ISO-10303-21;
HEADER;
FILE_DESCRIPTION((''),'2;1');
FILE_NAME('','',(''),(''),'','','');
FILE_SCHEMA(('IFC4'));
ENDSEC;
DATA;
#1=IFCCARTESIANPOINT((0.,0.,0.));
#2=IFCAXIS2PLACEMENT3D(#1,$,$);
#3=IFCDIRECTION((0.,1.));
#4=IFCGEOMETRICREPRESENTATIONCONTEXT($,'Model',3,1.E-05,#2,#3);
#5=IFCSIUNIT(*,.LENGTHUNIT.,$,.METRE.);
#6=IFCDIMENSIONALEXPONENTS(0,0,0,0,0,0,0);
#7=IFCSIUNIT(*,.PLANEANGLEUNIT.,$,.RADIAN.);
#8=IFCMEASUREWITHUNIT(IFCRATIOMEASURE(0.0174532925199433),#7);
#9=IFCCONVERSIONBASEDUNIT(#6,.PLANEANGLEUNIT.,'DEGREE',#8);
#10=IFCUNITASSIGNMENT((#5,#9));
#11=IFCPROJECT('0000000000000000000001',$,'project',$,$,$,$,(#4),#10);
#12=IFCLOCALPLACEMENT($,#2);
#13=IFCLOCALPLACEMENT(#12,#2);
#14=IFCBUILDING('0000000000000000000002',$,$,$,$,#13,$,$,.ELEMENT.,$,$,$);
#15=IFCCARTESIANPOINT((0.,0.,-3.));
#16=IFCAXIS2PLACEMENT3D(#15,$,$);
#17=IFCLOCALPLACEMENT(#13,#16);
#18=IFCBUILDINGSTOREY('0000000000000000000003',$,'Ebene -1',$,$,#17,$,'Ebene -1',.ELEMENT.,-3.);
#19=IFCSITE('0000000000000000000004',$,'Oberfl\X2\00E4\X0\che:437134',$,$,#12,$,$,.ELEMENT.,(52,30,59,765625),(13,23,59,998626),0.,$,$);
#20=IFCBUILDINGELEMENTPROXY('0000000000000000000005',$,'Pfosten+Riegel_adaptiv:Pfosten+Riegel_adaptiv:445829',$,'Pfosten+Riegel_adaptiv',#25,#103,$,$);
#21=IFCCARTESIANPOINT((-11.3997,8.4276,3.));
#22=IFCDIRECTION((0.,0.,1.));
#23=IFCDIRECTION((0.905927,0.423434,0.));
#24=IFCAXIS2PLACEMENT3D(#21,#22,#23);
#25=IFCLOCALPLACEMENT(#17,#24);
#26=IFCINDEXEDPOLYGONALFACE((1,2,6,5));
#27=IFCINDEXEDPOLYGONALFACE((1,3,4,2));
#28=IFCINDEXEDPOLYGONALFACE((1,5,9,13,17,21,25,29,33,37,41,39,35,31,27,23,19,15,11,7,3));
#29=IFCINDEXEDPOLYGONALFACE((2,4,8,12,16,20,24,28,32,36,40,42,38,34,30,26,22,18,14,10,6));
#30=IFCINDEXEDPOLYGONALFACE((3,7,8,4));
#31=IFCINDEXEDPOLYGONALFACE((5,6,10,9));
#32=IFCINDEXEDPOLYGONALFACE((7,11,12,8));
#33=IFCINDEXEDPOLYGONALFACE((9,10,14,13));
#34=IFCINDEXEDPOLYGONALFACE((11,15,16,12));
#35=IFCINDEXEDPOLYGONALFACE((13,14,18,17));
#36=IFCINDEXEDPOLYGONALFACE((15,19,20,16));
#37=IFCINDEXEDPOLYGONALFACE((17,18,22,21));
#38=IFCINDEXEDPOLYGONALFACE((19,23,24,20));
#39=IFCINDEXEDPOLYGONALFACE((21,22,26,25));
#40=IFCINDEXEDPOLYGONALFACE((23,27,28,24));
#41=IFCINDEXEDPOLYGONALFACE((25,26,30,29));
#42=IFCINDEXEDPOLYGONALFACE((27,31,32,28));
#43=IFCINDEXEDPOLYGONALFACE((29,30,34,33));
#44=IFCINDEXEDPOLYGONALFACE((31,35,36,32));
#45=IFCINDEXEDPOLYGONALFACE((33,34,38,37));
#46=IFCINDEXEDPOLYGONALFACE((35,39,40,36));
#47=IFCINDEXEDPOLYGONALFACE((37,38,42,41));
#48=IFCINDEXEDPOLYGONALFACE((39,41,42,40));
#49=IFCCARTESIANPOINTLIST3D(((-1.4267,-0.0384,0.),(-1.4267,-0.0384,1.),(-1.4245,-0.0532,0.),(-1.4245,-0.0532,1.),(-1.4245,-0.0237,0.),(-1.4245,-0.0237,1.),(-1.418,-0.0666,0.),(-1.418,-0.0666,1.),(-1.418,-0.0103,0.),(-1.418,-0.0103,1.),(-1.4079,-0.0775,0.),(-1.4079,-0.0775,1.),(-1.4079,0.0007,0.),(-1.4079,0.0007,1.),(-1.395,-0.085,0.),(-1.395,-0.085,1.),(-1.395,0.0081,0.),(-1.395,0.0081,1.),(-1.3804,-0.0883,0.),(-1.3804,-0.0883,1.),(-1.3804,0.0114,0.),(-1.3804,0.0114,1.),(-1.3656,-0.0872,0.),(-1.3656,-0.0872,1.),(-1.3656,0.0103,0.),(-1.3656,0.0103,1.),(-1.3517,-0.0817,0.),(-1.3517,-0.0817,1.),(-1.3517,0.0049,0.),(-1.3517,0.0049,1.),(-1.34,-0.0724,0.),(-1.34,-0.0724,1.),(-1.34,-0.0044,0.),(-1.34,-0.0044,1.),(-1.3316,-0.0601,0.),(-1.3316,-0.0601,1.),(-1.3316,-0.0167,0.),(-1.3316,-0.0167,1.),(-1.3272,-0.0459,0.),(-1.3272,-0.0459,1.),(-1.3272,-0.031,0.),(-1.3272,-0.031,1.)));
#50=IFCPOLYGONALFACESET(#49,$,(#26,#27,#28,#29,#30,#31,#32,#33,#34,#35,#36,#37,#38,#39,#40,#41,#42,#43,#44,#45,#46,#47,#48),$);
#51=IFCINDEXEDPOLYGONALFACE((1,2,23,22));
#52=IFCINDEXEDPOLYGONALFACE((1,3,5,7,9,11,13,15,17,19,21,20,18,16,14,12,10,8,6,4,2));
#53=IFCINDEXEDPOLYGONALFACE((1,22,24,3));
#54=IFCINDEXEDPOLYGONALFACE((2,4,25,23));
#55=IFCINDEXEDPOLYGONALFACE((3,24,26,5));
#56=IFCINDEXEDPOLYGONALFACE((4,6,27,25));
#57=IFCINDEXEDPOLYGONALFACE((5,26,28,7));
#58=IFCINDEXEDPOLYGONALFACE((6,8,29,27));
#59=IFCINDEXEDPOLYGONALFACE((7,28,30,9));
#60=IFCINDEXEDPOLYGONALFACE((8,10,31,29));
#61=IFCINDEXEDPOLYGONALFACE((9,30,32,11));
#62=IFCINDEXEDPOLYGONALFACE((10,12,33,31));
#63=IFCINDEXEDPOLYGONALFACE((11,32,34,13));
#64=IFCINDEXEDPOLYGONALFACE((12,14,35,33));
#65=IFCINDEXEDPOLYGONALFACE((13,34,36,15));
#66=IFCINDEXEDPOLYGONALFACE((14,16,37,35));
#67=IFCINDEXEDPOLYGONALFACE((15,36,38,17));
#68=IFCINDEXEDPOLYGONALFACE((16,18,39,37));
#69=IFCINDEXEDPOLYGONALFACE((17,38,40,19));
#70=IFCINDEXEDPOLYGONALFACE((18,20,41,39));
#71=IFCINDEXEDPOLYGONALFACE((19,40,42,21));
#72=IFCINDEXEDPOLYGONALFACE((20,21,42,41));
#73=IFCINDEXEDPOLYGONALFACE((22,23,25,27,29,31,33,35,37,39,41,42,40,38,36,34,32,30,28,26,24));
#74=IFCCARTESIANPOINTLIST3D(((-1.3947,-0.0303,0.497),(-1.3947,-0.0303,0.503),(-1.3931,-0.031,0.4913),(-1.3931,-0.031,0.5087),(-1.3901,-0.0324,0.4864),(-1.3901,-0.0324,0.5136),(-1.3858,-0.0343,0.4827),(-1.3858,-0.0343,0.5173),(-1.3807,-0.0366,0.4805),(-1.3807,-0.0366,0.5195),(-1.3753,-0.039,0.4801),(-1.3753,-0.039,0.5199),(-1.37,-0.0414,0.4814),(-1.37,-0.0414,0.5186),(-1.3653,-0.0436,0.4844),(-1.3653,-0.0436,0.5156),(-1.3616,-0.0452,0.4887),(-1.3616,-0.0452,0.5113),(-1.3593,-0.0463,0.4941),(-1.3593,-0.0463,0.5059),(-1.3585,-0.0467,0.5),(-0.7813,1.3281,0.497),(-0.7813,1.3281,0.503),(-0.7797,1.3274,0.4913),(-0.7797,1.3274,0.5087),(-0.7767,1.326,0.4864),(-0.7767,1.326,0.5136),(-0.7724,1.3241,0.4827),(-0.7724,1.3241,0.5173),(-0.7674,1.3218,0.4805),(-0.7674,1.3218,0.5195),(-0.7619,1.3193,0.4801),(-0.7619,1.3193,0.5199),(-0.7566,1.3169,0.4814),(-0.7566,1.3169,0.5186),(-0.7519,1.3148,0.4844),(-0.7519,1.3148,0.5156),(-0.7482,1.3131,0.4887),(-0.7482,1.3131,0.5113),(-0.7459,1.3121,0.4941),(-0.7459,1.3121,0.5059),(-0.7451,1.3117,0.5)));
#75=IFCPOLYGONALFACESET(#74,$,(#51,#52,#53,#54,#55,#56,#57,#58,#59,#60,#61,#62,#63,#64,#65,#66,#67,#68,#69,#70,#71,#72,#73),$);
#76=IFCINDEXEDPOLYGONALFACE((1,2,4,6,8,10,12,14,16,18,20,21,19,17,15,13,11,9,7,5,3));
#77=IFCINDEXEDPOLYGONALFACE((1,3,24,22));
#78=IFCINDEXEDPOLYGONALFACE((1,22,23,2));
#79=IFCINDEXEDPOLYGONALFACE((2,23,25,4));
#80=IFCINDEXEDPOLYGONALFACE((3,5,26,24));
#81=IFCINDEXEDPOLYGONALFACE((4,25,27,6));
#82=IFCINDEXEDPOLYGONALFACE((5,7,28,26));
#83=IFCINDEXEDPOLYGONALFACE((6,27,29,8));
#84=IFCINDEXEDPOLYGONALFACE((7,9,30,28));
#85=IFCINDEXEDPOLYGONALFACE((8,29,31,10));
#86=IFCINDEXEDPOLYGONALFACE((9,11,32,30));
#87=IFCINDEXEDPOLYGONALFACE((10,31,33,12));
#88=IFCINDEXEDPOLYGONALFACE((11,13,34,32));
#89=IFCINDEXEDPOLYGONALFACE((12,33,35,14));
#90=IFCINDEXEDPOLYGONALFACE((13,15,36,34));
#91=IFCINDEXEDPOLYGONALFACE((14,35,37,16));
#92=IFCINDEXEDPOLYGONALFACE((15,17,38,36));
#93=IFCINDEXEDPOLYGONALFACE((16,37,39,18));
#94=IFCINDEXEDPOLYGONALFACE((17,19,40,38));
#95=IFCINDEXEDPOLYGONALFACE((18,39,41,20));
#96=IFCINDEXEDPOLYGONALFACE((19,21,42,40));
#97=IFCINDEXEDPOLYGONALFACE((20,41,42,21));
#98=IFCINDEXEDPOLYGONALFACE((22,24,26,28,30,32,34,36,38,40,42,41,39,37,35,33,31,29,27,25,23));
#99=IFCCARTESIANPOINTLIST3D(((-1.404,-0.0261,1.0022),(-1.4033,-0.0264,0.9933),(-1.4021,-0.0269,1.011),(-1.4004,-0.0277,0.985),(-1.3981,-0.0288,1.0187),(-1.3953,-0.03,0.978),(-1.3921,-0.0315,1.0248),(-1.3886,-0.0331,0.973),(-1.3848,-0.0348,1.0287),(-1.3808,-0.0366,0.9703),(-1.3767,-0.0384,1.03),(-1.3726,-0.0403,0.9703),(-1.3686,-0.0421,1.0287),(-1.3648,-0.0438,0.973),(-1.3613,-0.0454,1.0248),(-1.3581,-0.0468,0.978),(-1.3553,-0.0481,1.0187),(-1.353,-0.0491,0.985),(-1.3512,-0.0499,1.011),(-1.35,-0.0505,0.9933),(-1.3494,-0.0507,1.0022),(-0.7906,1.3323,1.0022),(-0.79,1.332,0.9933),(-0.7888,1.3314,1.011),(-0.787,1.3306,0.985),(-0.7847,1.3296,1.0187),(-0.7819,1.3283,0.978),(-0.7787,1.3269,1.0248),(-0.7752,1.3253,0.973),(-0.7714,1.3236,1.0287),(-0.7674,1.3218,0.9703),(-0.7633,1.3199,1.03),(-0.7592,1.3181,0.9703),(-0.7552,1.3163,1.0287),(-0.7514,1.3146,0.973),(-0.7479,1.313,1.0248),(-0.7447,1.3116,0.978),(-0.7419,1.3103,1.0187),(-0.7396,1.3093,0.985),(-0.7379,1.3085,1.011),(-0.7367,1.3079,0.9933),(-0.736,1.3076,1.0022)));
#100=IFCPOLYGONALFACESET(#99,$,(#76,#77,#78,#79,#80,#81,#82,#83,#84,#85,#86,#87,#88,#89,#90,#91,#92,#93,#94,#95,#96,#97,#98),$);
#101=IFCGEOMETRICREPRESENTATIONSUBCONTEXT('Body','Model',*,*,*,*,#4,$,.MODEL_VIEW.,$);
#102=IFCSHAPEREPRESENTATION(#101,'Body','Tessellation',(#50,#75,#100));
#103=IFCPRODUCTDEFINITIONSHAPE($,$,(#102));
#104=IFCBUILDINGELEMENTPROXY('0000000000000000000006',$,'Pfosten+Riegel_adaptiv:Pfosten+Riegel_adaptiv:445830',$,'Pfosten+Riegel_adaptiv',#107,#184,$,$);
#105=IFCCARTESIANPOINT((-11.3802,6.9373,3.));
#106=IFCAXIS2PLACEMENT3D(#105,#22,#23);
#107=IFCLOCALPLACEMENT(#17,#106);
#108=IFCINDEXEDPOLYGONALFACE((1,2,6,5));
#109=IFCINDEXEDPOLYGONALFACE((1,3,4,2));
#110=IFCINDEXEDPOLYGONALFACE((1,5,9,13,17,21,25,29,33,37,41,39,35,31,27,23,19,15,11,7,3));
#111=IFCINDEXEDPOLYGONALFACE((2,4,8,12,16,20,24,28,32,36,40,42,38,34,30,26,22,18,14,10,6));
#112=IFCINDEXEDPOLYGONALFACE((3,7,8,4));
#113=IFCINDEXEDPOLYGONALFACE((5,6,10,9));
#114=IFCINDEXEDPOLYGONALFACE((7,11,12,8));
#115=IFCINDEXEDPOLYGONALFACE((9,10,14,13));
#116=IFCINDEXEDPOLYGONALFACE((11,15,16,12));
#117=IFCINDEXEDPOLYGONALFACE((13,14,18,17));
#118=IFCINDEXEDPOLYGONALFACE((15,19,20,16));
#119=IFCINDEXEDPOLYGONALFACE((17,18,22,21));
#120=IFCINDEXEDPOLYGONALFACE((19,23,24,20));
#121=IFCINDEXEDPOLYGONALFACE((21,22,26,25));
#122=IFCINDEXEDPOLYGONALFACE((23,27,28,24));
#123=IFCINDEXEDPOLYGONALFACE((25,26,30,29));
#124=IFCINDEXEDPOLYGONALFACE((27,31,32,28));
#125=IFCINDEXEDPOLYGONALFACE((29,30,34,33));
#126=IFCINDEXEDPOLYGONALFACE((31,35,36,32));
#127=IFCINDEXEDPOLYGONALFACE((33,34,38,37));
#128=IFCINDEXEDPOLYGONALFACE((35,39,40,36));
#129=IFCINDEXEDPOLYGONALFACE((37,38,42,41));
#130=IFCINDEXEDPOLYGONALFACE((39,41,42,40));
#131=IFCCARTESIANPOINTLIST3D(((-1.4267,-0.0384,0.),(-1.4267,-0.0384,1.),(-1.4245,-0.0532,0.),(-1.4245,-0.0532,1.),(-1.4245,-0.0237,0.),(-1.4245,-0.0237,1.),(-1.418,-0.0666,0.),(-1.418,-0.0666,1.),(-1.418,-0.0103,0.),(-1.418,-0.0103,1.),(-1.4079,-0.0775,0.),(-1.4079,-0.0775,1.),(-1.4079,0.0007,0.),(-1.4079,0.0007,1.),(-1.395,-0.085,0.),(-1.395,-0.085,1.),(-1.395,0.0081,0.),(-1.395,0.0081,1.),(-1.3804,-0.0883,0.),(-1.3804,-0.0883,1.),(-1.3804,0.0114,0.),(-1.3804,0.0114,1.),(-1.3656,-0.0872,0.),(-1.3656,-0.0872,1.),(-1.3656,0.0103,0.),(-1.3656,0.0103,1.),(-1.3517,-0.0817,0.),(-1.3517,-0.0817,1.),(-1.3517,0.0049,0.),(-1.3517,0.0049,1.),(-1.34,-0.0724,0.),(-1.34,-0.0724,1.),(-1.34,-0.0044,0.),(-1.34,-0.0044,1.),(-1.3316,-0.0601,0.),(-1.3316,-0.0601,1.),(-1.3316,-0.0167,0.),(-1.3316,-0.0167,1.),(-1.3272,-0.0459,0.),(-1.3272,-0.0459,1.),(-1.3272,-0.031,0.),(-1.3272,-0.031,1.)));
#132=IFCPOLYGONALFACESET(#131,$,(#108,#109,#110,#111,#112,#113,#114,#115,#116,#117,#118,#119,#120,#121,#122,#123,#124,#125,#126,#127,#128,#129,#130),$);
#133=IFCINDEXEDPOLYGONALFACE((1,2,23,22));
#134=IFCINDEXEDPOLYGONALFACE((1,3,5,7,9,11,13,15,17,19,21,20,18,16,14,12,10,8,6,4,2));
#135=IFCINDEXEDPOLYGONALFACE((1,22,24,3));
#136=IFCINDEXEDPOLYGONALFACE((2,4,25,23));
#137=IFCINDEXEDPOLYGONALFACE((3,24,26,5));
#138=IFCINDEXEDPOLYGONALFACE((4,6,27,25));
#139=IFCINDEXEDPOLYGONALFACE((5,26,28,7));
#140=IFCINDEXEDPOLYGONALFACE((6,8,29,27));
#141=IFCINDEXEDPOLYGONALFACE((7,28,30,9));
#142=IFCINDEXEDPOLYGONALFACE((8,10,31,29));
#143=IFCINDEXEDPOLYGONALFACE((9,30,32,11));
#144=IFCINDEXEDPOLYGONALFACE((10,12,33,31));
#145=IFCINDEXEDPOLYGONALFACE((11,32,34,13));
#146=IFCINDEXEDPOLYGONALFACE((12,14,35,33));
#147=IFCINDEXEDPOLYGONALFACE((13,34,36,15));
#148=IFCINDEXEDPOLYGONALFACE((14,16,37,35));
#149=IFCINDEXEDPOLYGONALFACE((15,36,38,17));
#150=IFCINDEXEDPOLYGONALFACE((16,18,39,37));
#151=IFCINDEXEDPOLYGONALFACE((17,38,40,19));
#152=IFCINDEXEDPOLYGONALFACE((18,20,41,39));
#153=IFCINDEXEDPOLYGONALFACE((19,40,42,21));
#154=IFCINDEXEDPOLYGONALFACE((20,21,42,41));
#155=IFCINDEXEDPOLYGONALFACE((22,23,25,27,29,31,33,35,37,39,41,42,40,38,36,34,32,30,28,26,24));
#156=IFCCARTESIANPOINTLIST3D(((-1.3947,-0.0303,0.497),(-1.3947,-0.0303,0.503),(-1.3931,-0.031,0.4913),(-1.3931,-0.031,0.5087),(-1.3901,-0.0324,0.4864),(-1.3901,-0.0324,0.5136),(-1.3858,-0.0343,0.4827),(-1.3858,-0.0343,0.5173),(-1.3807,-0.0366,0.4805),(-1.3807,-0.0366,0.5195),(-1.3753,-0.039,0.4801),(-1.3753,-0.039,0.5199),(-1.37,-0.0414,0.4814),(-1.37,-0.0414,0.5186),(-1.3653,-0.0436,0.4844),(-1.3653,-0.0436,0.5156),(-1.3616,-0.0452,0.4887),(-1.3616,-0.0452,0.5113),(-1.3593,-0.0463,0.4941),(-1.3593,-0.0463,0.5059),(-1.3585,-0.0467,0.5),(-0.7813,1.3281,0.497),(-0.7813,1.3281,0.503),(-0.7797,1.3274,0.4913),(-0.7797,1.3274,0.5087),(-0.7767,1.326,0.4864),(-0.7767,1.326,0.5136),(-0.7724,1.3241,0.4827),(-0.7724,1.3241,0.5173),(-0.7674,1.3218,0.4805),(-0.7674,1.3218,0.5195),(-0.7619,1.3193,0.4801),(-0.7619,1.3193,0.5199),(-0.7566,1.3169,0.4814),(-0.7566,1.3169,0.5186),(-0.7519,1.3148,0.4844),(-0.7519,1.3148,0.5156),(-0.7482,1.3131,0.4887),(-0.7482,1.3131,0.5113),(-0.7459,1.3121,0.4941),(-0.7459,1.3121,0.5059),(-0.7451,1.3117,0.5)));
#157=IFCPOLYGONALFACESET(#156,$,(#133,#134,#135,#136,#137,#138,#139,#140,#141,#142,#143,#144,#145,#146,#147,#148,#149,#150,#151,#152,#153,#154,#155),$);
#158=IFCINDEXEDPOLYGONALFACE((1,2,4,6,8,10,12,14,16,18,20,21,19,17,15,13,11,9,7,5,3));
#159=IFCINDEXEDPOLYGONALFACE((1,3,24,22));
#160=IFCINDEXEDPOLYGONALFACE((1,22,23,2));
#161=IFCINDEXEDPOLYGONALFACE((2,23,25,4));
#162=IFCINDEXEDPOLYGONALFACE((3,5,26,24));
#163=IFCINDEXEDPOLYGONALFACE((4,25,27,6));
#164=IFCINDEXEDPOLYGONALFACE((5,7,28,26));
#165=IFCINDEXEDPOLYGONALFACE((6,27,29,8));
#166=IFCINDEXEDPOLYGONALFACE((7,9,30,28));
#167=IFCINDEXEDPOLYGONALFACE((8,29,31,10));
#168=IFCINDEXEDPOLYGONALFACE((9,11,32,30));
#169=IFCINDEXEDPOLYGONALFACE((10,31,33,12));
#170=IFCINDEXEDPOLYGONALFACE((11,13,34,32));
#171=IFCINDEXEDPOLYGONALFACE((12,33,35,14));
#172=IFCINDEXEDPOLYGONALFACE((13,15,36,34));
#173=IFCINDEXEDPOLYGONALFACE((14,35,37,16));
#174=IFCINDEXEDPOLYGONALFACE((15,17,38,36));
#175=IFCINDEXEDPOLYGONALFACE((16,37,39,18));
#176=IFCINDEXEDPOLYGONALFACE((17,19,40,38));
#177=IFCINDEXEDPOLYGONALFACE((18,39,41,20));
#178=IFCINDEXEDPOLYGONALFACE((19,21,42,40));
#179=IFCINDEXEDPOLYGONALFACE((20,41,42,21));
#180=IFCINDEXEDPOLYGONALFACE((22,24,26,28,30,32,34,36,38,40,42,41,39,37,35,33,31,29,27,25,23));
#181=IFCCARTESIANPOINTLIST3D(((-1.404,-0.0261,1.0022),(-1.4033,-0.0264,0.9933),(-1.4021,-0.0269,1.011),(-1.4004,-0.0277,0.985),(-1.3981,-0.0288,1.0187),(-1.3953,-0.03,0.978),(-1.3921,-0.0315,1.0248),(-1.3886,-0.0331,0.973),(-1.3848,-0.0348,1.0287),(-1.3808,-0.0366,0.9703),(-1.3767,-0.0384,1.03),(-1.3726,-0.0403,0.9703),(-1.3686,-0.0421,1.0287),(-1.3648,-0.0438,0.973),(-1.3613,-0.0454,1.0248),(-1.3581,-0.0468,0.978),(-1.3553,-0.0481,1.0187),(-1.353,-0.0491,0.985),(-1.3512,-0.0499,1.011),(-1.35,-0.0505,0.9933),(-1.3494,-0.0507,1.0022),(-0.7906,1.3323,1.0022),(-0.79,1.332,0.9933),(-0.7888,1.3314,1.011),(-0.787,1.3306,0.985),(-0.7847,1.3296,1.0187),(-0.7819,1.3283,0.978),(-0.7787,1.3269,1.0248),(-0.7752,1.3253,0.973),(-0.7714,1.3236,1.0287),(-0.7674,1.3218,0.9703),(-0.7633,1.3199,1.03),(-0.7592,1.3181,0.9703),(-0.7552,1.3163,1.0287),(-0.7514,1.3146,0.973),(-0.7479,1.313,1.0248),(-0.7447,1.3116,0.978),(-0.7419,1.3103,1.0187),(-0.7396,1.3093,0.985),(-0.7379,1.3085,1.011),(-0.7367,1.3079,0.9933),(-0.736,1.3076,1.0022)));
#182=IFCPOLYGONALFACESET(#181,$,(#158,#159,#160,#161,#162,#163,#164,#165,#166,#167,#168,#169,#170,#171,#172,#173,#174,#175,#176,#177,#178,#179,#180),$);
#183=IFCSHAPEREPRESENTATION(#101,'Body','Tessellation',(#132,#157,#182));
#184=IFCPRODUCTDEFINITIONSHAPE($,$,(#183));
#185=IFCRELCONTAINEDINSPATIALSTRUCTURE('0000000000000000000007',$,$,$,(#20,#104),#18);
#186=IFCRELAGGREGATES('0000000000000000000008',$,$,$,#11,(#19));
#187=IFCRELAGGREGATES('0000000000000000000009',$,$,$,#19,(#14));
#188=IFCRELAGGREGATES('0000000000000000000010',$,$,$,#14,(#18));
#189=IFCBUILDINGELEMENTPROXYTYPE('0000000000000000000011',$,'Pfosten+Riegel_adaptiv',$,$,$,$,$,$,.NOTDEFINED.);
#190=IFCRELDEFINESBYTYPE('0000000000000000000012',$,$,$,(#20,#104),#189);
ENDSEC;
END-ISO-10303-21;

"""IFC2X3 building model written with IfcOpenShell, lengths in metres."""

from ifc_helpers import new_model, entity, si_unit, converted_unit, direction, frame, frame_2d, origin, place, context, subcontext, project, spatial, circle, extrude, source, transform, mapped, type_object, type_shapes, element, save


model = new_model("IFC2X3")

# Units and contexts
model_context = context("Model", 3, precision=1e-05, world=origin(), true_north=direction((0.0, 1.0)))
body_context = subcontext(model_context, "Body", "Model", "MODEL_VIEW")
ifc_project = project(units=[si_unit("LENGTHUNIT", "METRE"), converted_unit("PLANEANGLEUNIT", "DEGREE", entity("IfcRatioMeasure", 0.0174532925199433), si_unit("PLANEANGLEUNIT", "RADIAN"), dimensions=[0, 0, 0, 0, 0, 0, 0])], contexts=[model_context])

# Site, building, storey
site_placement = place(None, origin())
site = spatial("IfcSite", under=ifc_project, at=site_placement, Name="Oberfläche:437134", CompositionType="ELEMENT", RefLatitude=(52, 30, 59, 765625), RefLongitude=(13, 23, 59, 998626), RefElevation=0.0)
building_placement = place(site_placement, origin())
building = spatial("IfcBuilding", under=site, at=building_placement, CompositionType="ELEMENT")
storey_placement = place(building_placement, frame((0.0, 0.0, -3.0)))
storey = spatial("IfcBuildingStorey", under=building, at=storey_placement, Name="Ebene -1", LongName="Ebene -1", CompositionType="ELEMENT", Elevation=-3.0)

# Building element proxies
building_element_proxy_type_1 = type_object("IfcBuildingElementProxyType", Name="Pfosten+Riegel_adaptiv", PredefinedType="NOTDEFINED")
shared_shape_1 = source(origin(), body_context, "Body", "SweptSolid", [
    extrude(circle(Radius=0.05, at=frame_2d((0.0, 0.0), x_axis=(1.0, 0.0))), frame((-1.3767, -0.0384, 0.0), z_axis=(0.0, 0.0, 1.0), x_axis=(-1.0, 0.0, 0.0)), (0.0, 0.0, 1.0), 1.0),
    extrude(circle(Radius=0.02, at=frame_2d((0.0, 0.0), x_axis=(1.0, 0.0))), frame((-1.3767, -0.0384, 0.5), z_axis=(0.411546, 0.911389, 0.0), x_axis=(0.911389, -0.411546, 0.0)), (0.0, 0.0, 1.0), 1.4904),
    extrude(circle(Radius=0.03, at=frame_2d((0.0, 0.0), x_axis=(1.0, 0.0))), frame((-1.3767, -0.0384, 1.0), z_axis=(0.411546, 0.911389, 0.0), x_axis=(0.0, 0.0, 1.0)), (0.0, 0.0, 1.0), 1.4904),
])
type_shapes(building_element_proxy_type_1, [shared_shape_1])
for number, where, z_axis, x_axis, name in (
    (1, (-11.3997, 8.4276, 3.0), (0.0, 0.0, 1.0), (0.905927, 0.423434, 0.0), "Pfosten+Riegel_adaptiv:Pfosten+Riegel_adaptiv:445829"),
    (2, (-11.3802, 6.9373, 3.0), (0.0, 0.0, 1.0), (0.905927, 0.423434, 0.0), "Pfosten+Riegel_adaptiv:Pfosten+Riegel_adaptiv:445830"),
):
    element("IfcBuildingElementProxy", number, at=place(storey_placement, frame(where, z_axis=z_axis, x_axis=x_axis)), inside=storey, type_object=building_element_proxy_type_1, Name=name, ObjectType="Pfosten+Riegel_adaptiv", context=body_context, shape_type="MappedRepresentation", body=[
        mapped(shared_shape_1, transform((0.0, 0.0, 0.0), scale=1.0)),
    ])

save(model, "model.ifc")
